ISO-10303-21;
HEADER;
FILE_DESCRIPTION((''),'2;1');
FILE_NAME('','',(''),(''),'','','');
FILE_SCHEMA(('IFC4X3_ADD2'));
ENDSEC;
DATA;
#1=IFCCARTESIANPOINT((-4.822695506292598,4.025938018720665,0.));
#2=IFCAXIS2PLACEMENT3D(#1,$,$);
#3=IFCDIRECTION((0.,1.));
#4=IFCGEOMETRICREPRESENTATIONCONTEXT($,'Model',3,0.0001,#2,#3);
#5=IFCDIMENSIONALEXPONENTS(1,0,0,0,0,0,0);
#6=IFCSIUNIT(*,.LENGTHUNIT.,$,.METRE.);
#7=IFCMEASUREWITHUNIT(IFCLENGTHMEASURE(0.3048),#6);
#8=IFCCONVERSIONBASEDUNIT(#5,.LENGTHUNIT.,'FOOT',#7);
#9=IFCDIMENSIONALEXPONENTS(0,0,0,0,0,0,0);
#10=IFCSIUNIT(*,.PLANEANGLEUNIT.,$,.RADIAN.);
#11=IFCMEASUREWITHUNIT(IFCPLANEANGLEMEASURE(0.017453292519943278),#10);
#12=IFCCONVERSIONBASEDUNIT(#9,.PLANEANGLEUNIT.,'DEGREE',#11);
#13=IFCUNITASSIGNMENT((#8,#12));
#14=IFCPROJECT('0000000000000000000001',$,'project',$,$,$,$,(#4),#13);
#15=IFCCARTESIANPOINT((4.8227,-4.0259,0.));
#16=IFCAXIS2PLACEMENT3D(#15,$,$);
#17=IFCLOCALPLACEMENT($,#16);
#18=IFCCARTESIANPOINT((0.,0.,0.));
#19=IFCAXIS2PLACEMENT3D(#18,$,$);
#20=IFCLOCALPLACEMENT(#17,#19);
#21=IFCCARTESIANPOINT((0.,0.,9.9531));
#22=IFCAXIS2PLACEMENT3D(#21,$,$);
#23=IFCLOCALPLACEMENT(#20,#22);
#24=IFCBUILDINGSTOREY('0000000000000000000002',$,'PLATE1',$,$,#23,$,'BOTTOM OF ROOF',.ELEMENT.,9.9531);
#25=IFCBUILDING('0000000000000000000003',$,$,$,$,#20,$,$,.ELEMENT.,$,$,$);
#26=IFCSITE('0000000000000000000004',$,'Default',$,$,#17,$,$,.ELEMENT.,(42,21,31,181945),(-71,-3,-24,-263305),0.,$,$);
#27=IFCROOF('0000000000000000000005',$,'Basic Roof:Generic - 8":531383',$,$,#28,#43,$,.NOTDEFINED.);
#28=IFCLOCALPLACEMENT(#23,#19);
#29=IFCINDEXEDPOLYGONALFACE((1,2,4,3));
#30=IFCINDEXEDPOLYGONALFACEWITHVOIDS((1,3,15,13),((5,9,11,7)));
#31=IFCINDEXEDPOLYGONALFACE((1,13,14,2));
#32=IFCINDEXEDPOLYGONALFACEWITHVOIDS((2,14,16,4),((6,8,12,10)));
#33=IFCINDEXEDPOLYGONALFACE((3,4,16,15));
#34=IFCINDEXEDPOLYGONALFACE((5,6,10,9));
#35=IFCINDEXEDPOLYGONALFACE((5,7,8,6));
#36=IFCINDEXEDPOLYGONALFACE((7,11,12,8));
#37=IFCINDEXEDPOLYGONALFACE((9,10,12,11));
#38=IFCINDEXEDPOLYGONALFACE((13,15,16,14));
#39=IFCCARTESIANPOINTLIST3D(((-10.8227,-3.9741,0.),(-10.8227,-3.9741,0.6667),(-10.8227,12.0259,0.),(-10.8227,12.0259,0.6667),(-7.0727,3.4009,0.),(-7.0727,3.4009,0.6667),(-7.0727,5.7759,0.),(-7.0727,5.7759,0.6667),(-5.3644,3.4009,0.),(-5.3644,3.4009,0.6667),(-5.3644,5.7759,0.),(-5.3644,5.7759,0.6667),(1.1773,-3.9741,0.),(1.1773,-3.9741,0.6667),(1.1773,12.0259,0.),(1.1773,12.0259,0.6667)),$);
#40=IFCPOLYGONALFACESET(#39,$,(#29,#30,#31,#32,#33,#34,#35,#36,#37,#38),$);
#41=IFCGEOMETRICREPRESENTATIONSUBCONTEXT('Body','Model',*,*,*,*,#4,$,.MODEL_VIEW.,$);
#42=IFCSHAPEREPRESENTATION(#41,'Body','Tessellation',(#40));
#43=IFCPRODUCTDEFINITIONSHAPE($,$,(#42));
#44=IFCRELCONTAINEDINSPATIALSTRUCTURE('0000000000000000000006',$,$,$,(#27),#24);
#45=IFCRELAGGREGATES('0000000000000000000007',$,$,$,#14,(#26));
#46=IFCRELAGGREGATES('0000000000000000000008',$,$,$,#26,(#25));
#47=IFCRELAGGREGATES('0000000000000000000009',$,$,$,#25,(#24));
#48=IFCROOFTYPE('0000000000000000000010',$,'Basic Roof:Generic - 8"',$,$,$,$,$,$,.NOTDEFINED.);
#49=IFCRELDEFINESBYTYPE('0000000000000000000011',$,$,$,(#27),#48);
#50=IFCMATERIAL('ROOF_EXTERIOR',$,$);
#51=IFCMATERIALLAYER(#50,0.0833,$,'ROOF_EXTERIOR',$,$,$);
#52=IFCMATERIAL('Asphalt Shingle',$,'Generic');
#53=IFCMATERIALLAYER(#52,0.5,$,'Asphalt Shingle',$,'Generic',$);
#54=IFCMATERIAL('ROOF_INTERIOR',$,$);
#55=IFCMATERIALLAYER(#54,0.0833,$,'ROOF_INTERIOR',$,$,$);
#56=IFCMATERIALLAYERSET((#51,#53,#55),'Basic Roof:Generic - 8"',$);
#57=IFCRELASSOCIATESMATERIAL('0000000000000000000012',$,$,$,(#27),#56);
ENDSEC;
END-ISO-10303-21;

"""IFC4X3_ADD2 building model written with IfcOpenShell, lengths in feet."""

from ifc_helpers import new_model, entity, si_unit, converted_unit, direction, frame, origin, origin_2d_with_axis, place, context, subcontext, project, spatial, rectangle, extrude, material, layer, layer_set, type_object, element, save


model = new_model("IFC4X3_ADD2")

# Units and contexts
model_context = context("Model", 3, precision=0.0001, world=frame((-4.822695506292598, 4.025938018720665, 0.0)), true_north=direction((0.0, 1.0)))
body_context = subcontext(model_context, "Body", "Model", "MODEL_VIEW")
ifc_project = project(units=[converted_unit("LENGTHUNIT", "FOOT", entity("IfcLengthMeasure", 0.3048), si_unit("LENGTHUNIT", "METRE"), dimensions=[1, 0, 0, 0, 0, 0, 0]), converted_unit("PLANEANGLEUNIT", "DEGREE", entity("IfcPlaneAngleMeasure", 0.017453292519943278), si_unit("PLANEANGLEUNIT", "RADIAN"), dimensions=[0, 0, 0, 0, 0, 0, 0])], contexts=[model_context])

# Site, building, storey
site_placement = place(None, frame((4.8227, -4.0259, 0.0)))
site = spatial("IfcSite", under=ifc_project, at=site_placement, Name="Default", CompositionType="ELEMENT", RefLatitude=(42, 21, 31, 181945), RefLongitude=(-71, -3, -24, -263305), RefElevation=0.0)
building_placement = place(site_placement, origin())
building = spatial("IfcBuilding", under=site, at=building_placement, CompositionType="ELEMENT")
storey_placement = place(building_placement, frame((0.0, 0.0, 9.9531)))
storey = spatial("IfcBuildingStorey", under=building, at=storey_placement, Name="PLATE1", LongName="BOTTOM OF ROOF", CompositionType="ELEMENT", Elevation=9.9531)

# Roof, opening
ifc_material_1 = material(Name="ROOF_EXTERIOR")
ifc_layer_1 = layer(ifc_material_1, 0.0833, Name="ROOF_EXTERIOR")
ifc_material_2 = material(Name="Asphalt Shingle", Category="Generic")
ifc_layer_2 = layer(ifc_material_2, 0.5, Name="Asphalt Shingle", Category="Generic")
ifc_material_3 = material(Name="ROOF_INTERIOR")
ifc_layer_3 = layer(ifc_material_3, 0.0833, Name="ROOF_INTERIOR")
ifc_layer_set_1 = layer_set([ifc_layer_1, ifc_layer_2, ifc_layer_3], Name="Basic Roof:Generic - 8\"")
roof_type = type_object("IfcRoofType", Name="Basic Roof:Generic - 8\"", PredefinedType="NOTDEFINED")
roof_placement = place(storey_placement, frame((-10.8227, -3.9741, 0.0)))
roof = element("IfcRoof", 1, at=roof_placement, inside=storey, type_object=roof_type, material=ifc_layer_set_1, Name="Basic Roof:Generic - 8\":531383", PredefinedType="NOTDEFINED", context=body_context, shape_type="SweptSolid", body=[
    extrude(rectangle(XDim=16.0, YDim=12.0, at=origin_2d_with_axis()), frame((6.0, 8.0, 0.0), z_axis=(0.0, 0.0, 1.0), x_axis=(0.0, -1.0, 0.0)), (0.0, 0.0, 1.0), 0.6667),
])
opening_placement = place(storey_placement, frame((-10.8227, -3.9741, 0.0)))
element("IfcOpeningElement", 2, at=opening_placement, cuts=roof, PredefinedType="OPENING", context=body_context, shape_type="SweptSolid", body=[
    extrude(rectangle(XDim=1.7083, YDim=2.375, at=origin_2d_with_axis()), frame((4.6042, 8.5625, 0.0), z_axis=(0.0, 0.0, 1.0), x_axis=(-1.0, 0.0, 0.0)), (0.0, 0.0, 1.0), 0.6667),
])

save(model, "model.ifc")
